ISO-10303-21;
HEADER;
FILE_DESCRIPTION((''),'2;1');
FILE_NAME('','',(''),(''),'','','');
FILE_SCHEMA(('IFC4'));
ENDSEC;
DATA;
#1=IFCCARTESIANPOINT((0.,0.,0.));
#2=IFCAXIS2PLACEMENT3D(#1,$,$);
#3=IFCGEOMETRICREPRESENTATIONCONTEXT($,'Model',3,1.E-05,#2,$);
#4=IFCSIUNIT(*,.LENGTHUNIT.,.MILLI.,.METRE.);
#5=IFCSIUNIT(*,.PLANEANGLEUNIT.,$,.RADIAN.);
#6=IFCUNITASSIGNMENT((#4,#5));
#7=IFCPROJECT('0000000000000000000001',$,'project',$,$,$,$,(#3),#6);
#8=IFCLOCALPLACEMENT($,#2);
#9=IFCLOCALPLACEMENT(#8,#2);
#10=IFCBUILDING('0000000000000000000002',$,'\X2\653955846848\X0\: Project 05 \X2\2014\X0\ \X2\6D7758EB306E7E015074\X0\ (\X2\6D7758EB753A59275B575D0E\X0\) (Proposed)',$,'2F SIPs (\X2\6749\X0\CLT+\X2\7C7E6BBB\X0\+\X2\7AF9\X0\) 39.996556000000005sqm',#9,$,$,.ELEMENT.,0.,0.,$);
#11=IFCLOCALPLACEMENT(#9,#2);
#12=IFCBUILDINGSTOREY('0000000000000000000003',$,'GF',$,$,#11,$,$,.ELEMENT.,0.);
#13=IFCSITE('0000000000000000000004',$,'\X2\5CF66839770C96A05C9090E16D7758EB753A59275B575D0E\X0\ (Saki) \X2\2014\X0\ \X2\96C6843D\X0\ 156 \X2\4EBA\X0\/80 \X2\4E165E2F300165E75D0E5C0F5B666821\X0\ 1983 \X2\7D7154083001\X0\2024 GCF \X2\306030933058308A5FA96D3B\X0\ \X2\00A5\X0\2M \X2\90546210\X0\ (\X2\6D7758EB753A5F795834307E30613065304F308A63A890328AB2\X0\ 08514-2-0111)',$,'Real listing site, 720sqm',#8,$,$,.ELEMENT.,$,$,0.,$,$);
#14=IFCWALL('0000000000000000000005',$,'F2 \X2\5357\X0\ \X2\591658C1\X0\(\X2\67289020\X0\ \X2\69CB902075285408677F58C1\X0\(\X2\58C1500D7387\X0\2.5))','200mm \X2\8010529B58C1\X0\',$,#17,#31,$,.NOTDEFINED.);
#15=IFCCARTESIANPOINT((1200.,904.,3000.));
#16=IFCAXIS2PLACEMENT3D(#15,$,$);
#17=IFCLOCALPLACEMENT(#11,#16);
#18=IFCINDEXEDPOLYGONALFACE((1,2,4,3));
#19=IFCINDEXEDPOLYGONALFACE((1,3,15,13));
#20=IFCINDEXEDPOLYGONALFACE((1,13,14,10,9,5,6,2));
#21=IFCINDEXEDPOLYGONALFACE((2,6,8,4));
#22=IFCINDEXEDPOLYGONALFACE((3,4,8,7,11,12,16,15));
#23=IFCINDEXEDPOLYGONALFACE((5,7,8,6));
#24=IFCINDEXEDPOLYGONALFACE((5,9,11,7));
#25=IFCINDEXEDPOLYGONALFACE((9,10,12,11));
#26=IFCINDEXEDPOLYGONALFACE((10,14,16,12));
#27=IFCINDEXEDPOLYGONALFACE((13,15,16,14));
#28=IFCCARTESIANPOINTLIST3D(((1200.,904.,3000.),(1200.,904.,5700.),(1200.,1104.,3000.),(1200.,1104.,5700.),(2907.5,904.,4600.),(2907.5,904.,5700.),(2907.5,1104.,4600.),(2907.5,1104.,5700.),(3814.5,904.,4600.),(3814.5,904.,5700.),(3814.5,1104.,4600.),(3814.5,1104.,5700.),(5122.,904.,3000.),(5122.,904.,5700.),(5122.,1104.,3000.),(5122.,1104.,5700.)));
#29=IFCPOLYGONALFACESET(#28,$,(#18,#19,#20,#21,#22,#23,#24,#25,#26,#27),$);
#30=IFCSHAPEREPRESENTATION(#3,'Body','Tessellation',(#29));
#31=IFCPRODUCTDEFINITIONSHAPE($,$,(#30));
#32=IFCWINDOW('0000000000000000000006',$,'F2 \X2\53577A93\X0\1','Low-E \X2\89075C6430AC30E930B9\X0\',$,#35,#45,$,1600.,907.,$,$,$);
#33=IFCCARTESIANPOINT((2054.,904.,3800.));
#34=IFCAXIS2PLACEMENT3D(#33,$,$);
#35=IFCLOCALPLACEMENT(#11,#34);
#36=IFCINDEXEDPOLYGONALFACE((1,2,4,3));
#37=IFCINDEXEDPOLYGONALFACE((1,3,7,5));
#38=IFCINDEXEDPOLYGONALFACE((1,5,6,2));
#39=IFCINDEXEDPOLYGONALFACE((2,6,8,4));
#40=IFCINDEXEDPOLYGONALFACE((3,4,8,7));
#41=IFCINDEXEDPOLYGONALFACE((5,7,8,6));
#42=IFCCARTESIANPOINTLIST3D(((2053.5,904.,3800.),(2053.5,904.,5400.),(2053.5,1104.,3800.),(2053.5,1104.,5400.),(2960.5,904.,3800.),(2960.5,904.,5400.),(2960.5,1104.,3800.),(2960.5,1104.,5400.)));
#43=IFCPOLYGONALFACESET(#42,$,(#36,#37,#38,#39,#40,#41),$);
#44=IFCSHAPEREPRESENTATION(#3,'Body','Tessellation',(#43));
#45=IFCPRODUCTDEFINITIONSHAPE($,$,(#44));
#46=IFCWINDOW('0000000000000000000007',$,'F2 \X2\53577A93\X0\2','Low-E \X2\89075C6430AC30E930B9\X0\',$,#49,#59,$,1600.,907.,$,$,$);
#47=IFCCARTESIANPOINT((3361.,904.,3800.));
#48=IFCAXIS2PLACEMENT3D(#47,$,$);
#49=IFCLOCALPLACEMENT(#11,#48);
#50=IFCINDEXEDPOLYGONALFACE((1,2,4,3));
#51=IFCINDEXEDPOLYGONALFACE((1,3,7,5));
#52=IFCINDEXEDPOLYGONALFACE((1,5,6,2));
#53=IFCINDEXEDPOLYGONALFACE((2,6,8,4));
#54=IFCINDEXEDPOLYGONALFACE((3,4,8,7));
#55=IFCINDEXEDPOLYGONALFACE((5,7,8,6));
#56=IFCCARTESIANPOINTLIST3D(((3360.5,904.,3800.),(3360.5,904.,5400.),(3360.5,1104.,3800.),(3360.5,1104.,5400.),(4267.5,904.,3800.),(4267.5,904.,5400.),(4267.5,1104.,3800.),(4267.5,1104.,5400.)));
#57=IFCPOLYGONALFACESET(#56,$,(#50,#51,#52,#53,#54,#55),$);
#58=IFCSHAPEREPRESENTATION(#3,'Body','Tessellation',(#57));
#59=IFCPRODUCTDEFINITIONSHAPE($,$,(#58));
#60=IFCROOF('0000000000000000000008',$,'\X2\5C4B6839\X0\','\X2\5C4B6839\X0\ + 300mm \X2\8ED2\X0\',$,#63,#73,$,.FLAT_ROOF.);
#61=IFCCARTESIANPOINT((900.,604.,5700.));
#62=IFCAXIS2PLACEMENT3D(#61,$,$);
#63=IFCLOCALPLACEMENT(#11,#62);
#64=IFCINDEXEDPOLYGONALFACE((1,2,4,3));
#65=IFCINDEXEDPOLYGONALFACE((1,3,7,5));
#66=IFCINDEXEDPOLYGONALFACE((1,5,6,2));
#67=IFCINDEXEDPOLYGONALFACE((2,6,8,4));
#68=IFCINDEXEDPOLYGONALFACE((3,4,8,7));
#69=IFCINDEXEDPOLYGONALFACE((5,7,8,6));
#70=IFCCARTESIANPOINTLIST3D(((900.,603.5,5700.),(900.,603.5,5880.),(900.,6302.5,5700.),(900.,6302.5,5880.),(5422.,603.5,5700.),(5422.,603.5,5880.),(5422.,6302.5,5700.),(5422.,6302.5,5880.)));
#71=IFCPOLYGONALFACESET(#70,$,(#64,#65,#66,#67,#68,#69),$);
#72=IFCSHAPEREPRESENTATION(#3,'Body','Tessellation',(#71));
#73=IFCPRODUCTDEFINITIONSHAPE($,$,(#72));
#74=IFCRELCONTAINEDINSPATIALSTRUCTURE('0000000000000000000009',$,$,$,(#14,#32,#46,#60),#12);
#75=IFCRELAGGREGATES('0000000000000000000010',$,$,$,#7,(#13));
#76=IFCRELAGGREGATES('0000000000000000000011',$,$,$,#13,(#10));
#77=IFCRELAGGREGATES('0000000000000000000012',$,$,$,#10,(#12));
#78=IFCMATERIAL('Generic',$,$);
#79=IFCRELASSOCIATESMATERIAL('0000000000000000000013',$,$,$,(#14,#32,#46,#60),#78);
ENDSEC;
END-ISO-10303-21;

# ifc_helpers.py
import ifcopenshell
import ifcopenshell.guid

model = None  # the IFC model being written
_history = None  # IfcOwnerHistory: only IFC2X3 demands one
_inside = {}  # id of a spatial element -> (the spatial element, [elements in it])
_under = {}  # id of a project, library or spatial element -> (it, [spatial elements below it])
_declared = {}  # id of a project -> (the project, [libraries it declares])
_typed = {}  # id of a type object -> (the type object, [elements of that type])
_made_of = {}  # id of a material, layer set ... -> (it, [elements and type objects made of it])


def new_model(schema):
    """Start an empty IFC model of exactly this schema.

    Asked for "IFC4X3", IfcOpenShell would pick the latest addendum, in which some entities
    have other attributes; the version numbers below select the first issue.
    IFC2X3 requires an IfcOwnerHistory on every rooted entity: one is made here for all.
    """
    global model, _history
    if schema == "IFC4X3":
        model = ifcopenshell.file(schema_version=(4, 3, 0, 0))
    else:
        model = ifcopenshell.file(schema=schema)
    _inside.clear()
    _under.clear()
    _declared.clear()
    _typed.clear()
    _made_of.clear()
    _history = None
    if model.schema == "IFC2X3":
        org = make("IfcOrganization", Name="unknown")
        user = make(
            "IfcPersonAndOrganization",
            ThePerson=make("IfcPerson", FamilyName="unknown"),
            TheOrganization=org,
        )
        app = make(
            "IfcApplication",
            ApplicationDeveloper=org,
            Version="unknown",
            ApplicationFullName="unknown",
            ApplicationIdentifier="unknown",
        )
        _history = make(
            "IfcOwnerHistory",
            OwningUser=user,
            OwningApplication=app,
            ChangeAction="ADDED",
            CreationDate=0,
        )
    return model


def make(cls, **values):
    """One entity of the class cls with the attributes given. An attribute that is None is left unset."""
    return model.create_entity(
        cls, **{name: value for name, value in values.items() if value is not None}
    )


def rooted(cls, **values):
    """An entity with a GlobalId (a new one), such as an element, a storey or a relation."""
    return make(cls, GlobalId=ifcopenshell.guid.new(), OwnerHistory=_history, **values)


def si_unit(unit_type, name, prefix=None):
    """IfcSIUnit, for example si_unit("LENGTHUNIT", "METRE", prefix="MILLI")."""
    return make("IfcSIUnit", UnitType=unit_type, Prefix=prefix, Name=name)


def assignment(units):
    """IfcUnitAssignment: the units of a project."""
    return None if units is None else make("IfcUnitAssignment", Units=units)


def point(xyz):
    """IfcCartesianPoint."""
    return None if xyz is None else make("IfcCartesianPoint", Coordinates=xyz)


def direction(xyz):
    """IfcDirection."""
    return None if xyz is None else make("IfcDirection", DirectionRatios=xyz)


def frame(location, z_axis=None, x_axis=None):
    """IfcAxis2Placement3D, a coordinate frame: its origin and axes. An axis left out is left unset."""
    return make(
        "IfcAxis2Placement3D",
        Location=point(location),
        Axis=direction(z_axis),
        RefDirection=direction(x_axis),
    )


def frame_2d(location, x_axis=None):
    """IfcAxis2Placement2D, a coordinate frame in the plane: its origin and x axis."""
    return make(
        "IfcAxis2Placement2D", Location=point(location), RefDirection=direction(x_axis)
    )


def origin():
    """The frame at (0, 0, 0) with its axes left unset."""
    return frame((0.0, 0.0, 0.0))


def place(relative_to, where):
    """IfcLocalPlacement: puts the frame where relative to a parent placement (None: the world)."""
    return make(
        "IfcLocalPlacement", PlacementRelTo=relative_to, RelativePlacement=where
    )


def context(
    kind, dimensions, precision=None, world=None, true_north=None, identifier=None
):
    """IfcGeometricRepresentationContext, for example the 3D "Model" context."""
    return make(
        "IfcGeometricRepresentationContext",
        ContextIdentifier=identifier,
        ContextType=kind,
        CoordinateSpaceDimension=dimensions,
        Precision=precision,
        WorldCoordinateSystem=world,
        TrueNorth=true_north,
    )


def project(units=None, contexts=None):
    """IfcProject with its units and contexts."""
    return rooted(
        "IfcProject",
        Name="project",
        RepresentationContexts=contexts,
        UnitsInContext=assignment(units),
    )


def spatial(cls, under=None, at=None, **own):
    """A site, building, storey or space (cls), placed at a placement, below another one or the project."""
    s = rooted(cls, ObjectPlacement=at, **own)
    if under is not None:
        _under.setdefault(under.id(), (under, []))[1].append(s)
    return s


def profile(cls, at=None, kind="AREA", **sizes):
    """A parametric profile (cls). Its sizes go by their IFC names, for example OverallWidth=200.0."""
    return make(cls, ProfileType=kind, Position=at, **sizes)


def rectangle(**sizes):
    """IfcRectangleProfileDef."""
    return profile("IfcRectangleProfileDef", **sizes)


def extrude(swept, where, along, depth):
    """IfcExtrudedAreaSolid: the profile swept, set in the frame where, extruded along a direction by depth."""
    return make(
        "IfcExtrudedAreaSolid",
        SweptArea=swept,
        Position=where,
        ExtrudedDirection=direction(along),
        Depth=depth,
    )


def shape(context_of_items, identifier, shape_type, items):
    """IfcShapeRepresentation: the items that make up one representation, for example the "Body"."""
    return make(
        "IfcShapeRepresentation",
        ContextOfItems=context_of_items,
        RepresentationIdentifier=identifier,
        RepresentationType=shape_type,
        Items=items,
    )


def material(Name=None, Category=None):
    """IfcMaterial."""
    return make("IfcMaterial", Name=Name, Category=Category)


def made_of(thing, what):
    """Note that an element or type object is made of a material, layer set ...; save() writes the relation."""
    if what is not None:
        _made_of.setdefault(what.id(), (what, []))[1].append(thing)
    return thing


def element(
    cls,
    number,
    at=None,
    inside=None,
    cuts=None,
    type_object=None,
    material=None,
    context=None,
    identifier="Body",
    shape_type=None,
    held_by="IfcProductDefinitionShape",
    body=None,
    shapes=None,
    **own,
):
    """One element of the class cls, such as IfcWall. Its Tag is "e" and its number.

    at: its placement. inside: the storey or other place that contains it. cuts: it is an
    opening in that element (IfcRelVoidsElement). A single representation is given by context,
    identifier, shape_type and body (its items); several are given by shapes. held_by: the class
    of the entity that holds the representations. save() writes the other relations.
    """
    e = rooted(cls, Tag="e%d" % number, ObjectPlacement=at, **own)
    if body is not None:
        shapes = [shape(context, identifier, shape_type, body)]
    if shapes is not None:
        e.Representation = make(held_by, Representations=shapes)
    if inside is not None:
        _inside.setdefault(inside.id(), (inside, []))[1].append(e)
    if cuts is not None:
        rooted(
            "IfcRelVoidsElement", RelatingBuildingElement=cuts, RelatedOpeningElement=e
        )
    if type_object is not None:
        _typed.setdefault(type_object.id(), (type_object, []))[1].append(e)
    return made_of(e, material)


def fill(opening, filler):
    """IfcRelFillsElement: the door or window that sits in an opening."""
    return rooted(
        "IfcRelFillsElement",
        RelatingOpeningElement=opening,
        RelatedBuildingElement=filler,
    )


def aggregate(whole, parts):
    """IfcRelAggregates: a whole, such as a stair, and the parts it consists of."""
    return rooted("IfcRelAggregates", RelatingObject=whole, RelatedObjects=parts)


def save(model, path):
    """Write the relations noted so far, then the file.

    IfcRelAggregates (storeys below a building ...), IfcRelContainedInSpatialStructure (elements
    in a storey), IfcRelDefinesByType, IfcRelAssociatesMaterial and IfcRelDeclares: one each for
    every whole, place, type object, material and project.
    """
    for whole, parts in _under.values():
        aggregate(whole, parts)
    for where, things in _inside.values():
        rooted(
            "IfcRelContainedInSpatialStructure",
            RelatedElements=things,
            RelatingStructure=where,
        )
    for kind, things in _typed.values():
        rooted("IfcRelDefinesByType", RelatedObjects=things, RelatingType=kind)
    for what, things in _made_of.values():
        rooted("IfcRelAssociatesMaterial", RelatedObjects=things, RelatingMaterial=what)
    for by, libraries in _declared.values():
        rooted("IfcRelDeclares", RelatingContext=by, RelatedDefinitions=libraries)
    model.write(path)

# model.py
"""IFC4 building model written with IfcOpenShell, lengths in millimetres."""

from ifc_helpers import new_model, si_unit, frame, frame_2d, origin, place, context, project, spatial, rectangle, extrude, material, element, fill, save


model = new_model("IFC4")

# Units and contexts
model_context = context("Model", 3, precision=1e-05, world=origin())
ifc_project = project(units=[si_unit("LENGTHUNIT", "METRE", prefix="MILLI"), si_unit("PLANEANGLEUNIT", "RADIAN")], contexts=[model_context])

# Site, building, storey
site_placement = place(None, origin())
site = spatial("IfcSite", under=ifc_project, at=site_placement, Name="島根県隠岐郡海士町大字崎 (Saki) — 集落 156 人/80 世帯、旧崎小学校 1983 統合、2024 GCF だんじり復活 ¥2M 達成 (海士町役場まちづくり推進課 08514-2-0111)", ObjectType="Real listing site, 720sqm", CompositionType="ELEMENT", RefElevation=0.0)
building_placement = place(site_placement, origin())
building = spatial("IfcBuilding", under=site, at=building_placement, Name="改善案: Project 05 — 海士の縁側 (海士町大字崎) (Proposed)", ObjectType="2F SIPs (杉CLT+籾殻+竹) 39.996556000000005sqm", CompositionType="ELEMENT", ElevationOfRefHeight=0.0, ElevationOfTerrain=0.0)
storey_placement = place(building_placement, origin())
storey = spatial("IfcBuildingStorey", under=building, at=storey_placement, Name="GF", CompositionType="ELEMENT", Elevation=0.0)

# Shared definitions
ifc_material_1 = material(Name="Generic")

# Wall, openings, windows
wall_1_placement = place(storey_placement, frame((1200.0, 904.0, 3000.0)))
wall_1 = element("IfcWall", 1, at=wall_1_placement, inside=storey, material=ifc_material_1, Name="F2 南 外壁(木造 構造用合板壁(壁倍率2.5))", Description="200mm 耐力壁", PredefinedType="NOTDEFINED", context=model_context, shape_type="SweptSolid", body=[
    extrude(rectangle(XDim=3922.0, YDim=200.0, at=frame_2d((1961.0, 100.0))), frame((1200.0, 904.0, 3000.0)), (0.0, 0.0, 1.0), 2700.0),
])
opening_1_placement = place(storey_placement, frame((2054.0, 904.0, 3800.0)))
opening_1 = element("IfcOpeningElement", 2, at=opening_1_placement, cuts=wall_1, PredefinedType="NOTDEFINED", context=model_context, shape_type="SweptSolid", body=[
    extrude(rectangle(XDim=907.0, YDim=200.0, at=frame_2d((453.0, 100.0))), frame((2054.0, 904.0, 3800.0)), (0.0, 0.0, 1.0), 1600.0),
])
opening_2_placement = place(storey_placement, frame((3361.0, 904.0, 3800.0)))
opening_2 = element("IfcOpeningElement", 3, at=opening_2_placement, cuts=wall_1, PredefinedType="NOTDEFINED", context=model_context, shape_type="SweptSolid", body=[
    extrude(rectangle(XDim=907.0, YDim=200.0, at=frame_2d((453.0, 100.0))), frame((3361.0, 904.0, 3800.0)), (0.0, 0.0, 1.0), 1600.0),
])
window_1_placement = place(storey_placement, frame((2054.0, 904.0, 3800.0)))
window_1 = element("IfcWindow", 4, at=window_1_placement, inside=storey, material=ifc_material_1, Name="F2 南窓1", Description="Low-E 複層ガラス", OverallHeight=1600.0, OverallWidth=907.0, context=model_context, shape_type="SweptSolid", body=[
    extrude(rectangle(XDim=907.0, YDim=200.0, at=frame_2d((453.0, 100.0))), frame((2054.0, 904.0, 3800.0)), (0.0, 0.0, 1.0), 1600.0),
])
fill(opening_1, window_1)
window_2_placement = place(storey_placement, frame((3361.0, 904.0, 3800.0)))
window_2 = element("IfcWindow", 5, at=window_2_placement, inside=storey, material=ifc_material_1, Name="F2 南窓2", Description="Low-E 複層ガラス", OverallHeight=1600.0, OverallWidth=907.0, context=model_context, shape_type="SweptSolid", body=[
    extrude(rectangle(XDim=907.0, YDim=200.0, at=frame_2d((453.0, 100.0))), frame((3361.0, 904.0, 3800.0)), (0.0, 0.0, 1.0), 1600.0),
])
fill(opening_2, window_2)

# Roof
roof_placement = place(storey_placement, frame((900.0, 604.0, 5700.0)))
element("IfcRoof", 6, at=roof_placement, inside=storey, material=ifc_material_1, Name="屋根", Description="屋根 + 300mm 軒", PredefinedType="FLAT_ROOF", context=model_context, shape_type="SweptSolid", body=[
    extrude(rectangle(XDim=4522.0, YDim=5699.0, at=frame_2d((2261.0, 2849.0))), frame((900.0, 604.0, 5700.0)), (0.0, 0.0, 1.0), 180.0),
])

save(model, "model.ifc")
